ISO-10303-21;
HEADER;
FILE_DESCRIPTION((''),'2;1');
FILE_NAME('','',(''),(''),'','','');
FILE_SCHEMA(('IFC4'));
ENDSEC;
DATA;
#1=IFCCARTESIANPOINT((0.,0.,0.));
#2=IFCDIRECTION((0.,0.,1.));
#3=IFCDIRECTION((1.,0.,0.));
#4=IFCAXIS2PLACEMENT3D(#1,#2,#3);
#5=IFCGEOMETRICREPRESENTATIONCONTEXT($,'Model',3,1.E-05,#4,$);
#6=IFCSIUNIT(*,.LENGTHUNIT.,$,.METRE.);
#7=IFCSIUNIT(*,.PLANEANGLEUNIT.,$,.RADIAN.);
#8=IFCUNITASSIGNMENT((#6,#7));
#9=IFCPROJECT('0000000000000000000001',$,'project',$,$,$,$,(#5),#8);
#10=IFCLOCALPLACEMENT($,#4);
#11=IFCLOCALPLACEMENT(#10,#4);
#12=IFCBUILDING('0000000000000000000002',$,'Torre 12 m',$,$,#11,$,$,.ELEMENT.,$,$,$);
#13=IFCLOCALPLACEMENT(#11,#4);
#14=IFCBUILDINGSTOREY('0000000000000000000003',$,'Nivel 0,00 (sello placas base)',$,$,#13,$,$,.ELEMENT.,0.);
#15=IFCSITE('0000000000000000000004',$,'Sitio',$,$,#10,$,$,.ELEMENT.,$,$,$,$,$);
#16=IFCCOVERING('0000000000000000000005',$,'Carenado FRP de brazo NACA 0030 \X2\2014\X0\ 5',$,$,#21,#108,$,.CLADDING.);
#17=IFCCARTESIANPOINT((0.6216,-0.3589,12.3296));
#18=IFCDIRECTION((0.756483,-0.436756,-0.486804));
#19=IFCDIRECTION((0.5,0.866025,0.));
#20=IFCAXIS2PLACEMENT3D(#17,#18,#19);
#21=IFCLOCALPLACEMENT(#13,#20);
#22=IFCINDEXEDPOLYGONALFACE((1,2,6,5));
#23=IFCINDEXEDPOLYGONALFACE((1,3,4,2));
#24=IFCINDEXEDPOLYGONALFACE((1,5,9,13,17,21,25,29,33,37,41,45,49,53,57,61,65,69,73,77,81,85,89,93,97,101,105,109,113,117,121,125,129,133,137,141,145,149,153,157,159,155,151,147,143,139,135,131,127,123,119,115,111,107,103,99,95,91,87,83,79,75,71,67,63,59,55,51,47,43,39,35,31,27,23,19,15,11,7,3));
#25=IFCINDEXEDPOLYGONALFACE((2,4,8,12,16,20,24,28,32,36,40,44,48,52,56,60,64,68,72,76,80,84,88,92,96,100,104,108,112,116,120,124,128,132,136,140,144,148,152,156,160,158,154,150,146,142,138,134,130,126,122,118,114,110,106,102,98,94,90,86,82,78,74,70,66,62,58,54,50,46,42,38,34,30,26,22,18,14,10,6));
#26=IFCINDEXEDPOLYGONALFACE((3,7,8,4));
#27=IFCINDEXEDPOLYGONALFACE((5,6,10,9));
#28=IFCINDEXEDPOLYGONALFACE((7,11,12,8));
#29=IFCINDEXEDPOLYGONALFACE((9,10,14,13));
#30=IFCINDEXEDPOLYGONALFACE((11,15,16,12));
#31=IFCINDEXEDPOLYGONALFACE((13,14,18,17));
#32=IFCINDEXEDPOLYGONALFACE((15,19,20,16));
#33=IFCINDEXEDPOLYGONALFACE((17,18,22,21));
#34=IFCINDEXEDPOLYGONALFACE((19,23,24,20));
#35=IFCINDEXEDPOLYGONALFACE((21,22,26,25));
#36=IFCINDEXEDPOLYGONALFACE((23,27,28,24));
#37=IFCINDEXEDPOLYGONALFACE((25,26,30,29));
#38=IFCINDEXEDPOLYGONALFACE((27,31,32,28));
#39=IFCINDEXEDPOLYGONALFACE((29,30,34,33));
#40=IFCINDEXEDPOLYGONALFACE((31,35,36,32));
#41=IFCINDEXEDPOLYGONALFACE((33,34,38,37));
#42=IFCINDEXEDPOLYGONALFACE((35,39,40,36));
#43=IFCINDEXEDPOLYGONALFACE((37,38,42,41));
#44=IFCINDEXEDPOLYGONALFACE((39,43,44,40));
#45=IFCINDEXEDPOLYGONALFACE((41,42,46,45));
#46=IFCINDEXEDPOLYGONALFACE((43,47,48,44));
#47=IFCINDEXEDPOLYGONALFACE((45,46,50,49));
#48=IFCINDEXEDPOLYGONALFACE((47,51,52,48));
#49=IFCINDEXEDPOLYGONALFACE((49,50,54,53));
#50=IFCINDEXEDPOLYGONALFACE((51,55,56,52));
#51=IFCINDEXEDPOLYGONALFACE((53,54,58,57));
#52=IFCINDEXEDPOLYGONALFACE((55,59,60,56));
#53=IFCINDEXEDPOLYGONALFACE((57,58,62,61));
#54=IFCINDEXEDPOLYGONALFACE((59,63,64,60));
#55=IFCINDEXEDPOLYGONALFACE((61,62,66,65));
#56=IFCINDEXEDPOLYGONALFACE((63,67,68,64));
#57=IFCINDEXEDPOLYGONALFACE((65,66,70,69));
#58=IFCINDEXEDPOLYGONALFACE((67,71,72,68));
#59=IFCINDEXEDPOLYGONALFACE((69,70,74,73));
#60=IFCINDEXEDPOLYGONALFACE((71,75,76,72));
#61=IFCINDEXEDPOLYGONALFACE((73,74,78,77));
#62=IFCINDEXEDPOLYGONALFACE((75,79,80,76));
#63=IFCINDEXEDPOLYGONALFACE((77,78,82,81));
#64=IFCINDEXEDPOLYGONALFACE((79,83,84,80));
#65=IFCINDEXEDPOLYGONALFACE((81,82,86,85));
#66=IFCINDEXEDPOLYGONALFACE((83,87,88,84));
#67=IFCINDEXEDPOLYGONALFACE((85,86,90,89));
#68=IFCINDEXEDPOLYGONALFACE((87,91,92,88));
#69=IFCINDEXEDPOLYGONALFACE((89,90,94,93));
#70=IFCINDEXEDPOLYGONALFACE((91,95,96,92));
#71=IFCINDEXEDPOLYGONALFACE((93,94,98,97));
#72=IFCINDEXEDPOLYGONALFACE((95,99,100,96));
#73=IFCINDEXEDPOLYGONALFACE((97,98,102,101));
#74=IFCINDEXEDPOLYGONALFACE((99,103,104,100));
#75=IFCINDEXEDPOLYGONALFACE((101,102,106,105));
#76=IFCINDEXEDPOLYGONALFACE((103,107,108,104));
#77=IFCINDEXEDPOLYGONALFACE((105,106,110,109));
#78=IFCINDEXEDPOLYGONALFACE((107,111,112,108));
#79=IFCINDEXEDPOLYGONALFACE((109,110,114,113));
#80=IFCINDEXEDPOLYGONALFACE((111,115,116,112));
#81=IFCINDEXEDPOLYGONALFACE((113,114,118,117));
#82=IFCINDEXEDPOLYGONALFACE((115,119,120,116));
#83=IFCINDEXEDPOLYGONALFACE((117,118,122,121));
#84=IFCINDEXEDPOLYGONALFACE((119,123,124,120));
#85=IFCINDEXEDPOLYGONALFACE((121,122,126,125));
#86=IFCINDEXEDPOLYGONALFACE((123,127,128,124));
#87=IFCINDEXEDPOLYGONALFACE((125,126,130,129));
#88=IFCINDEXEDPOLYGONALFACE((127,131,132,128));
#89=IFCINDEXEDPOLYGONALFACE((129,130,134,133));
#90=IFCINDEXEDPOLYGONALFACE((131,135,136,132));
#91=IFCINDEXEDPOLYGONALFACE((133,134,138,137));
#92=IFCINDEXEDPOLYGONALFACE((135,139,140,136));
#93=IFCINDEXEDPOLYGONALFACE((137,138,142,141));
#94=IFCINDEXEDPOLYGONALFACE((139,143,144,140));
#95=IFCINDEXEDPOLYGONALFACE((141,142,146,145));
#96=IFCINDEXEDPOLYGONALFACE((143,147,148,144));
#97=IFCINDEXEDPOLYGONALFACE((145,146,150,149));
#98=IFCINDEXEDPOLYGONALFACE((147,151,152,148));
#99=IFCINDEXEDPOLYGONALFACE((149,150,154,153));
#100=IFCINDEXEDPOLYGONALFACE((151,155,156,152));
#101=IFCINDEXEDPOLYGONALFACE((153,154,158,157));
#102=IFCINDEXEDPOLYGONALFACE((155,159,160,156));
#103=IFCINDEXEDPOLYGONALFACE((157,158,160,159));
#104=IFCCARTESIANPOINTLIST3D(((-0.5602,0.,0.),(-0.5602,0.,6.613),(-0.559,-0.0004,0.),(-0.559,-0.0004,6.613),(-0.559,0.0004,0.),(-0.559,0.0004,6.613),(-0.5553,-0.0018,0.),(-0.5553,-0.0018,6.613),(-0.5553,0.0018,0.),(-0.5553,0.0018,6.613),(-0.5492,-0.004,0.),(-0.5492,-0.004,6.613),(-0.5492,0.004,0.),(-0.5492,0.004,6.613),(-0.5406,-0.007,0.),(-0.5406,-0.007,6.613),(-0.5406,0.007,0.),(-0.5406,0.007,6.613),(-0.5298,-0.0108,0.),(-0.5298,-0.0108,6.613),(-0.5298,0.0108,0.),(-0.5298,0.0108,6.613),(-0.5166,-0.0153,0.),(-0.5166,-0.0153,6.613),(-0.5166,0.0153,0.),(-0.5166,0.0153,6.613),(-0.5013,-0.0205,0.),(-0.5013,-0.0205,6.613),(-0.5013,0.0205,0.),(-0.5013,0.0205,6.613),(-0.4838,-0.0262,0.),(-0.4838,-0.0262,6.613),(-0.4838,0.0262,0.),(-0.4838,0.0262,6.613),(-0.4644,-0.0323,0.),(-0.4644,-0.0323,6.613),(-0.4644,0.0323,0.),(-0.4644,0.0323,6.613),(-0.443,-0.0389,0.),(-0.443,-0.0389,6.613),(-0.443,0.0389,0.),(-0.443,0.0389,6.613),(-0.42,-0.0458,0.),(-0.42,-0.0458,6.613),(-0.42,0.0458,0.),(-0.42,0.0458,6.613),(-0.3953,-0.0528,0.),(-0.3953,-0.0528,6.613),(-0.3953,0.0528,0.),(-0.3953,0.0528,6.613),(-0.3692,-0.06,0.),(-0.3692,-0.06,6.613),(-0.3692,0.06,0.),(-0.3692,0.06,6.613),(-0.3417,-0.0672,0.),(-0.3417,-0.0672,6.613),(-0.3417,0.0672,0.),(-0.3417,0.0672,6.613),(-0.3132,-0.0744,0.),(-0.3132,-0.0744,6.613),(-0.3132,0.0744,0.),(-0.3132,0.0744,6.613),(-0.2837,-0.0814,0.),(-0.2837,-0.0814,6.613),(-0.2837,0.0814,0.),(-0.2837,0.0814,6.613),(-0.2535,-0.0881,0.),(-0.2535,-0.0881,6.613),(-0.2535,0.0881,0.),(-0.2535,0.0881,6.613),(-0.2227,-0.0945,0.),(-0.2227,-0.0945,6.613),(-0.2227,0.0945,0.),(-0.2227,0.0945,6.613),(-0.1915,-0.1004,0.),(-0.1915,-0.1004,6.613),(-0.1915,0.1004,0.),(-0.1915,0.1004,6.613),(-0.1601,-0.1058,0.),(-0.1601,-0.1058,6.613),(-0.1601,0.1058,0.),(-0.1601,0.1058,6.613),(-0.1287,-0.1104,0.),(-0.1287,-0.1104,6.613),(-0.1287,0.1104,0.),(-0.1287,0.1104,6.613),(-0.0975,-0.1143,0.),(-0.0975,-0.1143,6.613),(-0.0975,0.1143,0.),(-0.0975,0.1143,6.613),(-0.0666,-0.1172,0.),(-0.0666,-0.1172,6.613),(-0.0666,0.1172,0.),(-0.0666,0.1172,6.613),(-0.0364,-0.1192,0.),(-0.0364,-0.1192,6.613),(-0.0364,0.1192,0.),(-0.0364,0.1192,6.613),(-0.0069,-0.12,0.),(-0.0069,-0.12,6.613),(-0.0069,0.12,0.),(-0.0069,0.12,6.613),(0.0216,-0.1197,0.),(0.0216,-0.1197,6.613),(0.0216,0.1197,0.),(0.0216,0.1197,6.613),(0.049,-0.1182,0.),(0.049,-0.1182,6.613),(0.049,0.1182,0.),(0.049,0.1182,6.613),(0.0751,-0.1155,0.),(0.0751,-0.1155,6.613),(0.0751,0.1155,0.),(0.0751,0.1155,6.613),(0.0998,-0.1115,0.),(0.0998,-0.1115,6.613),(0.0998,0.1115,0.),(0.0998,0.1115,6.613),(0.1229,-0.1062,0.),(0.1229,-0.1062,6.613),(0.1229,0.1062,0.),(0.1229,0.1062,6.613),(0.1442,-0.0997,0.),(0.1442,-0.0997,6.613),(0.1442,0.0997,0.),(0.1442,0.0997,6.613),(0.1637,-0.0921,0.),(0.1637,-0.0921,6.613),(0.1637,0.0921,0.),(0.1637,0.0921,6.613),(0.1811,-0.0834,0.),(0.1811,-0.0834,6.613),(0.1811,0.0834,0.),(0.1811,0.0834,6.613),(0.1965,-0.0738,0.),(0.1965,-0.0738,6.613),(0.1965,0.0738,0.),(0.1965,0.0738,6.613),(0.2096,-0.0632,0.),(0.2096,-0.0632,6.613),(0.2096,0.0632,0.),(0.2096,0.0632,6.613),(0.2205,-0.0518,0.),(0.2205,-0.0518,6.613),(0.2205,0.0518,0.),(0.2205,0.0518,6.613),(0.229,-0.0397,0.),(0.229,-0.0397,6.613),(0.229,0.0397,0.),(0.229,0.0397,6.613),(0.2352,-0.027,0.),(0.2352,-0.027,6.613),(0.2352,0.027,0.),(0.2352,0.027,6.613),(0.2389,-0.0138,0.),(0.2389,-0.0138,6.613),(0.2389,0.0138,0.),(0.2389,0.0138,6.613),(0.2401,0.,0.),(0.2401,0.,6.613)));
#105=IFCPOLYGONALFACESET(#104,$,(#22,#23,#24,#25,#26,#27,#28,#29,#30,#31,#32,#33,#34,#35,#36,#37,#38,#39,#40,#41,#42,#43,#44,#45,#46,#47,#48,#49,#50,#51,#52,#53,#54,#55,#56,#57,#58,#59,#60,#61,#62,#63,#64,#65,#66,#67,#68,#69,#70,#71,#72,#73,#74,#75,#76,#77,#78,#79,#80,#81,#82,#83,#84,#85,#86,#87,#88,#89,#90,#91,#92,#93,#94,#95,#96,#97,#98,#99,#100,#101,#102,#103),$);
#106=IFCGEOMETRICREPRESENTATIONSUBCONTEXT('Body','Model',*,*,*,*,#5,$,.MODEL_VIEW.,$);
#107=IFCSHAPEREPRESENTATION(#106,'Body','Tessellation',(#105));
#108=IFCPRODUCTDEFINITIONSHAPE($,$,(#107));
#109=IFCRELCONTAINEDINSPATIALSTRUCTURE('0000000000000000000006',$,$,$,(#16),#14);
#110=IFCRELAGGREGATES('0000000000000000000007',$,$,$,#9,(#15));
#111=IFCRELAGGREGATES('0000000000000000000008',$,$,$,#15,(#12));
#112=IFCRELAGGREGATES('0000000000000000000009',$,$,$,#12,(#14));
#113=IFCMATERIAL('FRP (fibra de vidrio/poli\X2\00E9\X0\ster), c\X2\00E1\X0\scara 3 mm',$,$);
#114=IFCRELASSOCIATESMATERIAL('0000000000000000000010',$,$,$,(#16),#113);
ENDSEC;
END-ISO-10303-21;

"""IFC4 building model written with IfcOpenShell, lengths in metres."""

from ifc_helpers import new_model, si_unit, frame, origin, origin_with_axes, place, context, subcontext, project, spatial, polyline, outline, extrude, material, element, save


model = new_model("IFC4")

# Units and contexts
model_context = context("Model", 3, precision=1e-05, world=origin_with_axes())
body_context = subcontext(model_context, "Body", "Model", "MODEL_VIEW")
ifc_project = project(units=[si_unit("LENGTHUNIT", "METRE"), si_unit("PLANEANGLEUNIT", "RADIAN")], contexts=[model_context])

# Site, building, storey
site_placement = place(None, origin_with_axes())
site = spatial("IfcSite", under=ifc_project, at=site_placement, Name="Sitio", CompositionType="ELEMENT")
building_placement = place(site_placement, origin_with_axes())
building = spatial("IfcBuilding", under=site, at=building_placement, Name="Torre 12 m", CompositionType="ELEMENT")
storey_placement = place(building_placement, origin_with_axes())
storey = spatial("IfcBuildingStorey", under=building, at=storey_placement, Name="Nivel 0,00 (sello placas base)", CompositionType="ELEMENT", Elevation=0.0)

# Covering
ifc_material_1 = material(Name="FRP (fibra de vidrio/poliéster), cáscara 3 mm")
covering_1_placement = place(storey_placement, frame((0.6216, -0.3589, 12.3296), z_axis=(0.756483, -0.436756, -0.486804), x_axis=(0.5, 0.866025, 0.0)))
element("IfcCovering", 1, at=covering_1_placement, inside=storey, material=ifc_material_1, Name="Carenado FRP de brazo NACA 0030 — 5", PredefinedType="CLADDING", context=body_context, shape_type="SweptSolid", body=[
    extrude(outline(polyline([(0.2401, 0.0), (0.2389, 0.0138), (0.2352, 0.027), (0.229, 0.0397), (0.2205, 0.0518), (0.2096, 0.0632), (0.1965, 0.0738), (0.1811, 0.0834), (0.1637, 0.0921), (0.1442, 0.0997), (0.1229, 0.1062), (0.0998, 0.1115), (0.0751, 0.1155), (0.049, 0.1182), (0.0216, 0.1197), (-0.0069, 0.12), (-0.0364, 0.1192), (-0.0666, 0.1172), (-0.0975, 0.1143), (-0.1287, 0.1104), (-0.1601, 0.1058), (-0.1915, 0.1004), (-0.2227, 0.0945), (-0.2535, 0.0881), (-0.2837, 0.0814), (-0.3132, 0.0744), (-0.3417, 0.0672), (-0.3692, 0.06), (-0.3953, 0.0528), (-0.42, 0.0458), (-0.443, 0.0389), (-0.4644, 0.0323), (-0.4838, 0.0262), (-0.5013, 0.0205), (-0.5166, 0.0153), (-0.5298, 0.0108), (-0.5406, 0.007), (-0.5492, 0.004), (-0.5553, 0.0018), (-0.559, 0.0004), (-0.5602, 0.0), (-0.559, -0.0004), (-0.5553, -0.0018), (-0.5492, -0.004), (-0.5406, -0.007), (-0.5298, -0.0108), (-0.5166, -0.0153), (-0.5013, -0.0205), (-0.4838, -0.0262), (-0.4644, -0.0323), (-0.443, -0.0389), (-0.42, -0.0458), (-0.3953, -0.0528), (-0.3692, -0.06), (-0.3417, -0.0672), (-0.3132, -0.0744), (-0.2837, -0.0814), (-0.2535, -0.0881), (-0.2227, -0.0945), (-0.1915, -0.1004), (-0.1601, -0.1058), (-0.1287, -0.1104), (-0.0975, -0.1143), (-0.0666, -0.1172), (-0.0364, -0.1192), (-0.0069, -0.12), (0.0216, -0.1197), (0.049, -0.1182), (0.0751, -0.1155), (0.0998, -0.1115), (0.1229, -0.1062), (0.1442, -0.0997), (0.1637, -0.0921), (0.1811, -0.0834), (0.1965, -0.0738), (0.2096, -0.0632), (0.2205, -0.0518), (0.229, -0.0397), (0.2352, -0.027), (0.2389, -0.0138), (0.2401, 0.0)])), origin(), (0.0, 0.0, 1.0), 6.613),
])

save(model, "model.ifc")
